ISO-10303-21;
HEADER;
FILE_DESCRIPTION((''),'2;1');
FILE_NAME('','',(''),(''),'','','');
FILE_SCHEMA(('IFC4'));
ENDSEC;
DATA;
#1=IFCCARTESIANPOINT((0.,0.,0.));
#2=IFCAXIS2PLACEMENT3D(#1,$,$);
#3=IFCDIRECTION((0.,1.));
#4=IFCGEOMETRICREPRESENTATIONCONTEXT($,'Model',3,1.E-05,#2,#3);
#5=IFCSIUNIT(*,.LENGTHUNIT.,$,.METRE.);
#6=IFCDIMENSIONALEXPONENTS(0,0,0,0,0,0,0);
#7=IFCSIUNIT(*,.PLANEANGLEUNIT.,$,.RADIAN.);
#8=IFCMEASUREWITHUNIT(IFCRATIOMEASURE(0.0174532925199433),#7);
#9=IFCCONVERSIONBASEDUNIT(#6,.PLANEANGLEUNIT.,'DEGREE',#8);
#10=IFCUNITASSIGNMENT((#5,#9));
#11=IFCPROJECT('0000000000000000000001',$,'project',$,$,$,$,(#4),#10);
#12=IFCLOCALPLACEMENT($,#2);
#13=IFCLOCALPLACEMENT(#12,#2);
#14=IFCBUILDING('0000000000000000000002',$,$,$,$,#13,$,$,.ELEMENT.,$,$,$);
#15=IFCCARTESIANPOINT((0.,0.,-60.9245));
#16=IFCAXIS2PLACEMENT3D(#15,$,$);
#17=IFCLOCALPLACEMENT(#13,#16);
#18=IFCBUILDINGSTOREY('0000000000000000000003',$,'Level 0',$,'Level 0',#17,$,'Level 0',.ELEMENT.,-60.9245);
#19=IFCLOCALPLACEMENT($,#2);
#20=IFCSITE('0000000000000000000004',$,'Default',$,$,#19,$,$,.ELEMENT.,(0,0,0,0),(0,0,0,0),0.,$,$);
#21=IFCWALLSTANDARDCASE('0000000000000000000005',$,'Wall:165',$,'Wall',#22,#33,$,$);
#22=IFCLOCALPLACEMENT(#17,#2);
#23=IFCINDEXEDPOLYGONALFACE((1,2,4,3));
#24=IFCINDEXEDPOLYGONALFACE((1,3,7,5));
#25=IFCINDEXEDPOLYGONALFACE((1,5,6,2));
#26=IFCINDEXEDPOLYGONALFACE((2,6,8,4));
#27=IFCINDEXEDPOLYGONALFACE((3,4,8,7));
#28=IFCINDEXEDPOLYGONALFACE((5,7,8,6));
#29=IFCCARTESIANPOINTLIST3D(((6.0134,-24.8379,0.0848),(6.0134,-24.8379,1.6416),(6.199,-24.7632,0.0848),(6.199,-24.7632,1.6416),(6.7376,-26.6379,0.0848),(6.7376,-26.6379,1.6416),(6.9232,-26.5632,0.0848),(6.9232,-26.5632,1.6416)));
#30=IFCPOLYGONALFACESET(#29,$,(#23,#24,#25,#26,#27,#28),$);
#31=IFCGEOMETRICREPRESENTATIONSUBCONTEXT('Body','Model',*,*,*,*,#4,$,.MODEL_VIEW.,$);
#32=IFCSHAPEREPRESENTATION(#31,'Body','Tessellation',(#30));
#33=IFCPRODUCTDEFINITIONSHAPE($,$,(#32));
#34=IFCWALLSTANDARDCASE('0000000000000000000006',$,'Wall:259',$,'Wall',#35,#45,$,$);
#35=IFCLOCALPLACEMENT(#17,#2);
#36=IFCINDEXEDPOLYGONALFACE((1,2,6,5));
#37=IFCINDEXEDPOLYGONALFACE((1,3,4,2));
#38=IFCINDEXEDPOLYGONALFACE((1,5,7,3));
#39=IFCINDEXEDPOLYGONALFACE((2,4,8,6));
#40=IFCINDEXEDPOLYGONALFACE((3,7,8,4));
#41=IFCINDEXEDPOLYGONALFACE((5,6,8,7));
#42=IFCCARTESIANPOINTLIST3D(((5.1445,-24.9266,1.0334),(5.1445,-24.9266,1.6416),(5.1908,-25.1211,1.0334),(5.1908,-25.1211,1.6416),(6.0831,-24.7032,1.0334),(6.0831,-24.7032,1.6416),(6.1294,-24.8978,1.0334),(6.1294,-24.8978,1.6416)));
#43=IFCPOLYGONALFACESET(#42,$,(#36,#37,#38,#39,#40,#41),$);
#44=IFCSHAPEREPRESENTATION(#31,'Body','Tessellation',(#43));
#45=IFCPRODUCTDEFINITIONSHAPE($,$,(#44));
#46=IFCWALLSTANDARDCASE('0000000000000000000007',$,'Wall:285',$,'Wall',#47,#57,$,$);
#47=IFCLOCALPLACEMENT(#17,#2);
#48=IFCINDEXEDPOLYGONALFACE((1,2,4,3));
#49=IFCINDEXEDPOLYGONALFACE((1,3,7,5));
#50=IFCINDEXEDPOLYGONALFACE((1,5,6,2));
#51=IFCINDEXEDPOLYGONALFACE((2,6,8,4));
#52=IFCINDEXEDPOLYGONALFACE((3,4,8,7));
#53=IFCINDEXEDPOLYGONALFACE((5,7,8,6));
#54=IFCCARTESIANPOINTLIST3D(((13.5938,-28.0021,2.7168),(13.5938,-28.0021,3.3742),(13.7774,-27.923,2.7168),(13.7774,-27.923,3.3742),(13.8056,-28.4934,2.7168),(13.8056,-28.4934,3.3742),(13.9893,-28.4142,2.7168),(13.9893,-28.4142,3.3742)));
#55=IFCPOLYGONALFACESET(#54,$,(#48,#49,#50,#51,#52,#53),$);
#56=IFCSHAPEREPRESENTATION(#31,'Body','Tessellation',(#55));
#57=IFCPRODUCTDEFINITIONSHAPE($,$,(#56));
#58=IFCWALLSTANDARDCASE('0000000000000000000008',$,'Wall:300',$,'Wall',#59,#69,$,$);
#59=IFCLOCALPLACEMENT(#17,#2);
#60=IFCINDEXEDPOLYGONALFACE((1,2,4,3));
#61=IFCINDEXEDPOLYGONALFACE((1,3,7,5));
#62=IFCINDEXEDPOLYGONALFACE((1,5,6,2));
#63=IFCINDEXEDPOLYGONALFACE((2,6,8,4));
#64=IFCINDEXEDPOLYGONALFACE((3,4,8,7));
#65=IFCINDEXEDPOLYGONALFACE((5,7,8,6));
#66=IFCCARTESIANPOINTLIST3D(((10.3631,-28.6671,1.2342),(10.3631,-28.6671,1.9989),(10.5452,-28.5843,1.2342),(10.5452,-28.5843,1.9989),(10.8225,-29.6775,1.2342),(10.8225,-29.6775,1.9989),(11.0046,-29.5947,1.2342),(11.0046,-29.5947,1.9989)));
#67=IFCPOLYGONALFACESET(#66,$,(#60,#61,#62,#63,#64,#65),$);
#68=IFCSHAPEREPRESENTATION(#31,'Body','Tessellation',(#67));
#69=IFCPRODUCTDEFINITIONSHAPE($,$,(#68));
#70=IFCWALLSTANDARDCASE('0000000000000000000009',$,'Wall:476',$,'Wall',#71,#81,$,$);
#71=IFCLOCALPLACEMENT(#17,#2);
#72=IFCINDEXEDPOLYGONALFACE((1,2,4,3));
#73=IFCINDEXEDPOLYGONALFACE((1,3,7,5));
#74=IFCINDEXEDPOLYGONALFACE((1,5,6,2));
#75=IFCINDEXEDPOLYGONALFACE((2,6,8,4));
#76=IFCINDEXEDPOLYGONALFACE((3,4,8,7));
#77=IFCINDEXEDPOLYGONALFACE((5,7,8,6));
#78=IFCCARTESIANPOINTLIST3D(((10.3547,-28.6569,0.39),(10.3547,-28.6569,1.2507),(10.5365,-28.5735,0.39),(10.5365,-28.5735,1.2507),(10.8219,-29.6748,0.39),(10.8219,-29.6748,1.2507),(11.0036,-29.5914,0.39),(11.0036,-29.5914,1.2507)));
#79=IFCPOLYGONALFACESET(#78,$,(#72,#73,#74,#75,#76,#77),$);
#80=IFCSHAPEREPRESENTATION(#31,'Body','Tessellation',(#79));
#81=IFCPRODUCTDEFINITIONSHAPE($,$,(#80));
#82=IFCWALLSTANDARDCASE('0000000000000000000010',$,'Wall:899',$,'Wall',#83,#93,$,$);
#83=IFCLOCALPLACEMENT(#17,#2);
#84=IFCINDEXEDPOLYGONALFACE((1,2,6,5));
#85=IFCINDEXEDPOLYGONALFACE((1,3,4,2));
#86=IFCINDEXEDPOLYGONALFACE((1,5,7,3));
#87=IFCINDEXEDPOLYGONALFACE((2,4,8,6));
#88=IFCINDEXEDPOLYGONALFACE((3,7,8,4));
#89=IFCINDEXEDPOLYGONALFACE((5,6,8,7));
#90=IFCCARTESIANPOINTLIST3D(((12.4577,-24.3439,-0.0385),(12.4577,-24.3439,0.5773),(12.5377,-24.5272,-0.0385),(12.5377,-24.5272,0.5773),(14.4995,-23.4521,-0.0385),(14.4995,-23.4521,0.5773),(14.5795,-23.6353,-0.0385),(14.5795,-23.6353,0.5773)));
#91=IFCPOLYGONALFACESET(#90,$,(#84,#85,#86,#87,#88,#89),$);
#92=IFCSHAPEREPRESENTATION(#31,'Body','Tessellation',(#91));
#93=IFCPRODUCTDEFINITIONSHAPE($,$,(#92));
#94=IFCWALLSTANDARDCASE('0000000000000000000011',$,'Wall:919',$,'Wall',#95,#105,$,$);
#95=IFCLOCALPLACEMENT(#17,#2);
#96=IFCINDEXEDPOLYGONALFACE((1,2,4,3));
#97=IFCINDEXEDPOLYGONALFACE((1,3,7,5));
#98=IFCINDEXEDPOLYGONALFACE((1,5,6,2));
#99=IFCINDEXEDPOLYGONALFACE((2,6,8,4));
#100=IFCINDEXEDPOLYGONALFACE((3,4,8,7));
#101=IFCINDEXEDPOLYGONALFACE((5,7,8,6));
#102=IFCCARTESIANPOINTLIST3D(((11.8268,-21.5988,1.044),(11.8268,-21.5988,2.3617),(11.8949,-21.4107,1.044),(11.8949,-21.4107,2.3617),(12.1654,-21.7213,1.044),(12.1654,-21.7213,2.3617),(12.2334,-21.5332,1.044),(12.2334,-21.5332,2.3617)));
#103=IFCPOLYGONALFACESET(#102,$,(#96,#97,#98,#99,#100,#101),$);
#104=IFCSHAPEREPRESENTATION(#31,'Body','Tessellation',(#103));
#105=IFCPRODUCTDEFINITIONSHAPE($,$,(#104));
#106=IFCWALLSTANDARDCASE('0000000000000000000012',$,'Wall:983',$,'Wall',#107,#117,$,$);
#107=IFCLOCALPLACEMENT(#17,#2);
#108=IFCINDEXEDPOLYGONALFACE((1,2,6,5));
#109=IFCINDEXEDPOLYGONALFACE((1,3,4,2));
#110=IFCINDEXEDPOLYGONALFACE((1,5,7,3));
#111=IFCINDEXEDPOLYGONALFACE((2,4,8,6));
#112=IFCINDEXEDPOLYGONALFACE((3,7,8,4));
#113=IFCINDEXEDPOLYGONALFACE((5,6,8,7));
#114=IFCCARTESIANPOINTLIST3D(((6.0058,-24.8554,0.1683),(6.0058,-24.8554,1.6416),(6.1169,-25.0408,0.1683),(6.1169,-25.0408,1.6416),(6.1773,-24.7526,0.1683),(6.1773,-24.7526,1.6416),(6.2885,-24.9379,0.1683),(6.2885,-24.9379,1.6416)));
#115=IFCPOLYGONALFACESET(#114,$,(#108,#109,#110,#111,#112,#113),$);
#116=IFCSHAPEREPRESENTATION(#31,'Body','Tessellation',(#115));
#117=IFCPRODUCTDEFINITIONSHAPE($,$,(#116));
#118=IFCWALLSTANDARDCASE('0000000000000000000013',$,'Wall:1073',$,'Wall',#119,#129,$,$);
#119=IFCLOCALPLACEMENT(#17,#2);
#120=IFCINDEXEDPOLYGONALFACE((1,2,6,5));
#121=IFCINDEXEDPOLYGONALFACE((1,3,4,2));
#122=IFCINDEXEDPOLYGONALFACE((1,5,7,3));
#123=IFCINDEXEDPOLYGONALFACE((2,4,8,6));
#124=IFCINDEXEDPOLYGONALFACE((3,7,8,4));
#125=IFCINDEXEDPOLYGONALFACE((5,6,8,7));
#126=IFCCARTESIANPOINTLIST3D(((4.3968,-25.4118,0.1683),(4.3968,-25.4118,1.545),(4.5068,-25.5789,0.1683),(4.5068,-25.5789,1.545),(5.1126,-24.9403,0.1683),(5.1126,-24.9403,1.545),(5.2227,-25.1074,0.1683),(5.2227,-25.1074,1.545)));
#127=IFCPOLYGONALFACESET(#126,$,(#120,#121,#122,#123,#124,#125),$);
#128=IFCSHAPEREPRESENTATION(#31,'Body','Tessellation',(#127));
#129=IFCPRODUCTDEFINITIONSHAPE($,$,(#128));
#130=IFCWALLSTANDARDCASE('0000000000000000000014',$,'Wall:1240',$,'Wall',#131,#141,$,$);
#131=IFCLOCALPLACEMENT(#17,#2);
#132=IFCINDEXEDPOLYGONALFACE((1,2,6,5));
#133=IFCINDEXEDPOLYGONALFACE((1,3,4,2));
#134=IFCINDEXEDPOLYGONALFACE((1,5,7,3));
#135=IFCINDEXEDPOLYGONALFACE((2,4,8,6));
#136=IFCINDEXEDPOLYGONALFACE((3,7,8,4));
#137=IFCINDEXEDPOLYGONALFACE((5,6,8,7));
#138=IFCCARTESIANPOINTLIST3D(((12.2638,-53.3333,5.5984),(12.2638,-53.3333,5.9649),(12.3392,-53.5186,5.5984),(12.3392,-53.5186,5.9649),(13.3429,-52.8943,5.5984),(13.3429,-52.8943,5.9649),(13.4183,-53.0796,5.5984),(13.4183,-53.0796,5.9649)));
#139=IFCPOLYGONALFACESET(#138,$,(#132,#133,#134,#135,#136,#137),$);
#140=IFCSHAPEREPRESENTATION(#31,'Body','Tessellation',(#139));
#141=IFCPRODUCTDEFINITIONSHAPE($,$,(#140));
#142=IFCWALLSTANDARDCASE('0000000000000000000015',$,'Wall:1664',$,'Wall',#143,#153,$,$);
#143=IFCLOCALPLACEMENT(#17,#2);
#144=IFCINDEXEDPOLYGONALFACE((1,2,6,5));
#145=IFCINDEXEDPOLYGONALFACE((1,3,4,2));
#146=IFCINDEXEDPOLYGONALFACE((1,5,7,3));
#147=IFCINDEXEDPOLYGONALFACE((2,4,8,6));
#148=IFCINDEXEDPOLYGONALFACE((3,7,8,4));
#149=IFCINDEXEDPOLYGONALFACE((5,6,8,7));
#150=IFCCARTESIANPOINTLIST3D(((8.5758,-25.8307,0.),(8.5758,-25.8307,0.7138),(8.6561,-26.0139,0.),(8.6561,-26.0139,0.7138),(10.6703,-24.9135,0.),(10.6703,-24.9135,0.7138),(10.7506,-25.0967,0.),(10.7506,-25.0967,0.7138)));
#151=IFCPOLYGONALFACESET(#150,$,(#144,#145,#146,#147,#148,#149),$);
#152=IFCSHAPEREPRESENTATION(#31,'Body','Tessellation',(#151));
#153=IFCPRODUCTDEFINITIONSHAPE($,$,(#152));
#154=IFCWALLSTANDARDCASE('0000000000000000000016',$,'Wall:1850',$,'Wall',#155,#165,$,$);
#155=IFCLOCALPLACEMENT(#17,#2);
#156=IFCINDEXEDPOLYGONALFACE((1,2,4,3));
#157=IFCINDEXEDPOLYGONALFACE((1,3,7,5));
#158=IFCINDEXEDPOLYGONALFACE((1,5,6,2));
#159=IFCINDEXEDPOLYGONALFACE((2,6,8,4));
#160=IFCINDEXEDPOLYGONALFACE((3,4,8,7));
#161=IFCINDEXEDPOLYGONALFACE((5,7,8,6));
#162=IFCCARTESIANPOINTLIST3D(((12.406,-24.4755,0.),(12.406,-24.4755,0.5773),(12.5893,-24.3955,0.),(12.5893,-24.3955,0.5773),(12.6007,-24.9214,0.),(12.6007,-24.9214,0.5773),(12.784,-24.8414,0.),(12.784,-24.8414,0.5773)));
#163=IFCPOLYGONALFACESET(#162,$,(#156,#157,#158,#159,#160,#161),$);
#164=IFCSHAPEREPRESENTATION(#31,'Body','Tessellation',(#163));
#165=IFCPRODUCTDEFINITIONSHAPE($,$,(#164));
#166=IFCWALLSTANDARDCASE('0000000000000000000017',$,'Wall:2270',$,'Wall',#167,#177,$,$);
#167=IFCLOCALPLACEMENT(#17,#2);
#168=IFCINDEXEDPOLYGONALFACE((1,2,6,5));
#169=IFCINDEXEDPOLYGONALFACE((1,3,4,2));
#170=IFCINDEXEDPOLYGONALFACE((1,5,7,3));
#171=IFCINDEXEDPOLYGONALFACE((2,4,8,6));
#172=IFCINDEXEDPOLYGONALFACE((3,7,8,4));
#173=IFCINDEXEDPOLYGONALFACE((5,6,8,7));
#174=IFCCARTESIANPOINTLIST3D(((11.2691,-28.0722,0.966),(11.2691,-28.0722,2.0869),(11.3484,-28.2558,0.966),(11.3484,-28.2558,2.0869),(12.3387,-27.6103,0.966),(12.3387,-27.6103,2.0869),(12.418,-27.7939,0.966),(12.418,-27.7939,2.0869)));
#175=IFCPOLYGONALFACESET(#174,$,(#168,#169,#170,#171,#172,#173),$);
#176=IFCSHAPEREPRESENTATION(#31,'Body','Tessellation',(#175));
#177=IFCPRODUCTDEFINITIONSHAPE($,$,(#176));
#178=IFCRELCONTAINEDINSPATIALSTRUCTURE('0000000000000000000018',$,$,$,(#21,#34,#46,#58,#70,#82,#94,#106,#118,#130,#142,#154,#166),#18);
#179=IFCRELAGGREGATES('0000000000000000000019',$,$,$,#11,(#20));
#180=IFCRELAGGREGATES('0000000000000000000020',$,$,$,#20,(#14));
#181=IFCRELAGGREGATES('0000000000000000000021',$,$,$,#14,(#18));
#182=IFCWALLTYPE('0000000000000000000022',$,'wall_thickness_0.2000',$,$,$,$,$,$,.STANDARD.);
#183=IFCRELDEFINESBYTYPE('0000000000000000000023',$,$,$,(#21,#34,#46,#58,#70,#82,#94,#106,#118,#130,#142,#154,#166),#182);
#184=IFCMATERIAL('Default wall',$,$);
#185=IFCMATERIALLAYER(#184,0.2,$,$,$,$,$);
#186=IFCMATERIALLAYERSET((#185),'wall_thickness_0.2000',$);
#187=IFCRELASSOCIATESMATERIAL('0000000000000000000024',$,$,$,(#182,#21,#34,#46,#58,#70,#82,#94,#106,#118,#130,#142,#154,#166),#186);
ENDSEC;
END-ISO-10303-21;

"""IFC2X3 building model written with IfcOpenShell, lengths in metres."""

from ifc_helpers import new_model, entity, si_unit, converted_unit, direction, frame, origin, place, context, subcontext, project, spatial, polyline, outline, extrude, material, layer, layer_set, layer_usage, type_object, element, save


model = new_model("IFC2X3")

# Units and contexts
model_context = context("Model", 3, precision=1e-05, world=origin(), true_north=direction((0.0, 1.0)))
body_context = subcontext(model_context, "Body", "Model", "MODEL_VIEW")
ifc_project = project(units=[si_unit("LENGTHUNIT", "METRE"), converted_unit("PLANEANGLEUNIT", "DEGREE", entity("IfcRatioMeasure", 0.0174532925199433), si_unit("PLANEANGLEUNIT", "RADIAN"), dimensions=[0, 0, 0, 0, 0, 0, 0])], contexts=[model_context])

# Site, building, storey
site_placement = place(None, origin())
site = spatial("IfcSite", under=ifc_project, at=site_placement, Name="Default", CompositionType="ELEMENT", RefLatitude=(0, 0, 0, 0), RefLongitude=(0, 0, 0, 0), RefElevation=0.0)
placement_1 = place(None, origin())
building_placement = place(placement_1, origin())
building = spatial("IfcBuilding", under=site, at=building_placement, CompositionType="ELEMENT")
storey_placement = place(building_placement, frame((0.0, 0.0, -60.9245)))
storey = spatial("IfcBuildingStorey", under=building, at=storey_placement, Name="Level 0", ObjectType="Level 0", LongName="Level 0", CompositionType="ELEMENT", Elevation=-60.9245)

# Walls
ifc_material = material(Name="Default wall")
ifc_layer = layer(ifc_material, 0.2)
ifc_layer_set = layer_set([ifc_layer], Name="wall_thickness_0.2000")
ifc_layer_usage = layer_usage(ifc_layer_set, "AXIS2", "POSITIVE", -0.1)
wall_type = type_object("IfcWallType", Name="wall_thickness_0.2000", PredefinedType="STANDARD", material=ifc_layer_set)
placement_2 = place(building_placement, frame((0.0, 0.0, -60.8397)))
wall_1_placement = place(placement_2, frame((6.8304, -26.6006, 0.0), z_axis=(0.0, 0.0, 1.0), x_axis=(-0.373248, 0.927731, 0.0)))
element("IfcWallStandardCase", 1, at=wall_1_placement, inside=storey, type_object=wall_type, material=ifc_layer_usage, Name="Wall:165", ObjectType="Wall", context=body_context, shape_type="SweptSolid", body=[
    extrude(outline(polyline([(1.9403, -0.1), (1.9403, 0.1), (0.0, 0.1), (0.0, -0.1), (1.9403, -0.1)])), origin(), (0.0, 0.0, 1.0), 1.5569),
])
placement_3 = place(building_placement, frame((0.0, 0.0, -59.8911)))
wall_2_placement = place(placement_3, frame((6.1062, -24.8005, 0.0), z_axis=(0.0, 0.0, 1.0), x_axis=(-0.97284, -0.231481, 0.0)))
element("IfcWallStandardCase", 2, at=wall_2_placement, inside=storey, type_object=wall_type, material=ifc_layer_usage, Name="Wall:259", ObjectType="Wall", context=body_context, shape_type="SweptSolid", body=[
    extrude(outline(polyline([(0.9648, -0.1), (0.9648, 0.1), (0.0, 0.1), (0.0, -0.1), (0.9648, -0.1)])), origin(), (0.0, 0.0, 1.0), 0.6083),
])
placement_4 = place(building_placement, frame((0.0, 0.0, -58.2077)))
wall_3_placement = place(placement_4, frame((13.8974, -28.4538, 0.0), z_axis=(0.0, 0.0, 1.0), x_axis=(-0.395948, 0.918273, 0.0)))
element("IfcWallStandardCase", 3, at=wall_3_placement, inside=storey, type_object=wall_type, material=ifc_layer_usage, Name="Wall:285", ObjectType="Wall", context=body_context, shape_type="SweptSolid", body=[
    extrude(outline(polyline([(0.535, -0.1), (0.535, 0.1), (0.0, 0.1), (0.0, -0.1), (0.535, -0.1)])), origin(), (0.0, 0.0, 1.0), 0.6574),
])
placement_5 = place(building_placement, frame((0.0, 0.0, -59.6903)))
wall_4_placement = place(placement_5, frame((10.4541, -28.6257, 0.0), z_axis=(0.0, 0.0, 1.0), x_axis=(0.413879, -0.910332, 0.0)))
element("IfcWallStandardCase", 4, at=wall_4_placement, inside=storey, type_object=wall_type, material=ifc_layer_usage, Name="Wall:300", ObjectType="Wall", context=body_context, shape_type="SweptSolid", body=[
    extrude(outline(polyline([(1.11, -0.1), (1.11, 0.1), (0.0, 0.1), (0.0, -0.1), (1.11, -0.1)])), origin(), (0.0, 0.0, 1.0), 0.7646),
])
placement_6 = place(building_placement, frame((0.0, 0.0, -60.5345)))
wall_5_placement = place(placement_6, frame((10.4456, -28.6152, 0.0), z_axis=(0.0, 0.0, 1.0), x_axis=(0.417071, -0.908874, 0.0)))
element("IfcWallStandardCase", 5, at=wall_5_placement, inside=storey, type_object=wall_type, material=ifc_layer_usage, Name="Wall:476", ObjectType="Wall", context=body_context, shape_type="SweptSolid", body=[
    extrude(outline(polyline([(1.12, -0.1), (1.12, 0.1), (0.0, 0.1), (0.0, -0.1), (1.12, -0.1)])), origin(), (0.0, 0.0, 1.0), 0.8607),
])
placement_7 = place(building_placement, frame((0.0, 0.0, -60.963)))
wall_6_placement = place(placement_7, frame((12.4977, -24.4355, 0.0), z_axis=(0.0, 0.0, 1.0), x_axis=(0.916398, 0.400268, 0.0)))
element("IfcWallStandardCase", 6, at=wall_6_placement, inside=storey, type_object=wall_type, material=ifc_layer_usage, Name="Wall:899", ObjectType="Wall", context=body_context, shape_type="SweptSolid", body=[
    extrude(outline(polyline([(2.2281, -0.1), (2.2281, 0.1), (0.0, 0.1), (0.0, -0.1), (2.2281, -0.1)])), origin(), (0.0, 0.0, 1.0), 0.6158),
])
placement_8 = place(building_placement, frame((0.0, 0.0, -59.8805)))
wall_7_placement = place(placement_8, frame((12.1994, -21.6273, 0.0), z_axis=(0.0, 0.0, 1.0), x_axis=(-0.940349, 0.340212, 0.0)))
element("IfcWallStandardCase", 7, at=wall_7_placement, inside=storey, type_object=wall_type, material=ifc_layer_usage, Name="Wall:919", ObjectType="Wall", context=body_context, shape_type="SweptSolid", body=[
    extrude(outline(polyline([(0.36, -0.1), (0.36, 0.1), (0.0, 0.1), (0.0, -0.1), (0.36, -0.1)])), origin(), (0.0, 0.0, 1.0), 1.3177),
])
placement_9 = place(building_placement, frame((0.0, 0.0, -60.7562)))
wall_8_placement = place(placement_9, frame((6.2027, -24.9893, 0.0), z_axis=(0.0, 0.0, 1.0), x_axis=(-0.514203, 0.857669, 0.0)))
element("IfcWallStandardCase", 8, at=wall_8_placement, inside=storey, type_object=wall_type, material=ifc_layer_usage, Name="Wall:983", ObjectType="Wall", context=body_context, shape_type="SweptSolid", body=[
    extrude(outline(polyline([(0.2161, -0.1), (0.2161, 0.1), (0.0, 0.1), (0.0, -0.1), (0.2161, -0.1)])), origin(), (0.0, 0.0, 1.0), 1.4733),
])
placement_10 = place(building_placement, frame((0.0, 0.0, -60.7562)))
wall_9_placement = place(placement_10, frame((5.1676, -25.0239, 0.0), z_axis=(0.0, 0.0, 1.0), x_axis=(-0.835116, -0.550074, 0.0)))
element("IfcWallStandardCase", 9, at=wall_9_placement, inside=storey, type_object=wall_type, material=ifc_layer_usage, Name="Wall:1073", ObjectType="Wall", context=body_context, shape_type="SweptSolid", body=[
    extrude(outline(polyline([(0.8571, -0.1), (0.8571, 0.1), (0.0, 0.1), (0.0, -0.1), (0.8571, -0.1)])), origin(), (0.0, 0.0, 1.0), 1.3767),
])
placement_11 = place(building_placement, frame((0.0, 0.0, -55.3261)))
wall_10_placement = place(placement_11, frame((12.3015, -53.426, 0.0), z_axis=(0.0, 0.0, 1.0), x_axis=(0.926278, 0.37684, 0.0)))
element("IfcWallStandardCase", 10, at=wall_10_placement, inside=storey, type_object=wall_type, material=ifc_layer_usage, Name="Wall:1240", ObjectType="Wall", context=body_context, shape_type="SweptSolid", body=[
    extrude(outline(polyline([(1.165, -0.1), (1.165, 0.1), (0.0, 0.1), (0.0, -0.1), (1.165, -0.1)])), origin(), (0.0, 0.0, 1.0), 0.3666),
])
wall_11_placement = place(storey_placement, frame((8.6159, -25.9223, 0.0), z_axis=(0.0, 0.0, 1.0), x_axis=(0.91602, 0.401133, 0.0)))
element("IfcWallStandardCase", 11, at=wall_11_placement, inside=storey, type_object=wall_type, material=ifc_layer_usage, Name="Wall:1664", ObjectType="Wall", context=body_context, shape_type="SweptSolid", body=[
    extrude(outline(polyline([(2.2865, -0.1), (2.2865, 0.1), (0.0, 0.1), (0.0, -0.1), (2.2865, -0.1)])), origin(), (0.0, 0.0, 1.0), 0.7138),
])
wall_12_placement = place(storey_placement, frame((12.6923, -24.8814, 0.0), z_axis=(0.0, 0.0, 1.0), x_axis=(-0.400082, 0.916479, 0.0)))
element("IfcWallStandardCase", 12, at=wall_12_placement, inside=storey, type_object=wall_type, material=ifc_layer_usage, Name="Wall:1850", ObjectType="Wall", context=body_context, shape_type="SweptSolid", body=[
    extrude(outline(polyline([(0.4866, -0.1), (0.4866, 0.1), (0.0, 0.1), (0.0, -0.1), (0.4866, -0.1)])), origin(), (0.0, 0.0, 1.0), 0.5773),
])
placement_12 = place(building_placement, frame((0.0, 0.0, -59.9585)))
wall_13_placement = place(placement_12, frame((11.3088, -28.164, 0.0), z_axis=(0.0, 0.0, 1.0), x_axis=(0.918041, 0.396484, 0.0)))
element("IfcWallStandardCase", 13, at=wall_13_placement, inside=storey, type_object=wall_type, material=ifc_layer_usage, Name="Wall:2270", ObjectType="Wall", context=body_context, shape_type="SweptSolid", body=[
    extrude(outline(polyline([(1.165, -0.1), (1.165, 0.1), (0.0, 0.1), (0.0, -0.1), (1.165, -0.1)])), origin(), (0.0, 0.0, 1.0), 1.1209),
])

save(model, "model.ifc")
